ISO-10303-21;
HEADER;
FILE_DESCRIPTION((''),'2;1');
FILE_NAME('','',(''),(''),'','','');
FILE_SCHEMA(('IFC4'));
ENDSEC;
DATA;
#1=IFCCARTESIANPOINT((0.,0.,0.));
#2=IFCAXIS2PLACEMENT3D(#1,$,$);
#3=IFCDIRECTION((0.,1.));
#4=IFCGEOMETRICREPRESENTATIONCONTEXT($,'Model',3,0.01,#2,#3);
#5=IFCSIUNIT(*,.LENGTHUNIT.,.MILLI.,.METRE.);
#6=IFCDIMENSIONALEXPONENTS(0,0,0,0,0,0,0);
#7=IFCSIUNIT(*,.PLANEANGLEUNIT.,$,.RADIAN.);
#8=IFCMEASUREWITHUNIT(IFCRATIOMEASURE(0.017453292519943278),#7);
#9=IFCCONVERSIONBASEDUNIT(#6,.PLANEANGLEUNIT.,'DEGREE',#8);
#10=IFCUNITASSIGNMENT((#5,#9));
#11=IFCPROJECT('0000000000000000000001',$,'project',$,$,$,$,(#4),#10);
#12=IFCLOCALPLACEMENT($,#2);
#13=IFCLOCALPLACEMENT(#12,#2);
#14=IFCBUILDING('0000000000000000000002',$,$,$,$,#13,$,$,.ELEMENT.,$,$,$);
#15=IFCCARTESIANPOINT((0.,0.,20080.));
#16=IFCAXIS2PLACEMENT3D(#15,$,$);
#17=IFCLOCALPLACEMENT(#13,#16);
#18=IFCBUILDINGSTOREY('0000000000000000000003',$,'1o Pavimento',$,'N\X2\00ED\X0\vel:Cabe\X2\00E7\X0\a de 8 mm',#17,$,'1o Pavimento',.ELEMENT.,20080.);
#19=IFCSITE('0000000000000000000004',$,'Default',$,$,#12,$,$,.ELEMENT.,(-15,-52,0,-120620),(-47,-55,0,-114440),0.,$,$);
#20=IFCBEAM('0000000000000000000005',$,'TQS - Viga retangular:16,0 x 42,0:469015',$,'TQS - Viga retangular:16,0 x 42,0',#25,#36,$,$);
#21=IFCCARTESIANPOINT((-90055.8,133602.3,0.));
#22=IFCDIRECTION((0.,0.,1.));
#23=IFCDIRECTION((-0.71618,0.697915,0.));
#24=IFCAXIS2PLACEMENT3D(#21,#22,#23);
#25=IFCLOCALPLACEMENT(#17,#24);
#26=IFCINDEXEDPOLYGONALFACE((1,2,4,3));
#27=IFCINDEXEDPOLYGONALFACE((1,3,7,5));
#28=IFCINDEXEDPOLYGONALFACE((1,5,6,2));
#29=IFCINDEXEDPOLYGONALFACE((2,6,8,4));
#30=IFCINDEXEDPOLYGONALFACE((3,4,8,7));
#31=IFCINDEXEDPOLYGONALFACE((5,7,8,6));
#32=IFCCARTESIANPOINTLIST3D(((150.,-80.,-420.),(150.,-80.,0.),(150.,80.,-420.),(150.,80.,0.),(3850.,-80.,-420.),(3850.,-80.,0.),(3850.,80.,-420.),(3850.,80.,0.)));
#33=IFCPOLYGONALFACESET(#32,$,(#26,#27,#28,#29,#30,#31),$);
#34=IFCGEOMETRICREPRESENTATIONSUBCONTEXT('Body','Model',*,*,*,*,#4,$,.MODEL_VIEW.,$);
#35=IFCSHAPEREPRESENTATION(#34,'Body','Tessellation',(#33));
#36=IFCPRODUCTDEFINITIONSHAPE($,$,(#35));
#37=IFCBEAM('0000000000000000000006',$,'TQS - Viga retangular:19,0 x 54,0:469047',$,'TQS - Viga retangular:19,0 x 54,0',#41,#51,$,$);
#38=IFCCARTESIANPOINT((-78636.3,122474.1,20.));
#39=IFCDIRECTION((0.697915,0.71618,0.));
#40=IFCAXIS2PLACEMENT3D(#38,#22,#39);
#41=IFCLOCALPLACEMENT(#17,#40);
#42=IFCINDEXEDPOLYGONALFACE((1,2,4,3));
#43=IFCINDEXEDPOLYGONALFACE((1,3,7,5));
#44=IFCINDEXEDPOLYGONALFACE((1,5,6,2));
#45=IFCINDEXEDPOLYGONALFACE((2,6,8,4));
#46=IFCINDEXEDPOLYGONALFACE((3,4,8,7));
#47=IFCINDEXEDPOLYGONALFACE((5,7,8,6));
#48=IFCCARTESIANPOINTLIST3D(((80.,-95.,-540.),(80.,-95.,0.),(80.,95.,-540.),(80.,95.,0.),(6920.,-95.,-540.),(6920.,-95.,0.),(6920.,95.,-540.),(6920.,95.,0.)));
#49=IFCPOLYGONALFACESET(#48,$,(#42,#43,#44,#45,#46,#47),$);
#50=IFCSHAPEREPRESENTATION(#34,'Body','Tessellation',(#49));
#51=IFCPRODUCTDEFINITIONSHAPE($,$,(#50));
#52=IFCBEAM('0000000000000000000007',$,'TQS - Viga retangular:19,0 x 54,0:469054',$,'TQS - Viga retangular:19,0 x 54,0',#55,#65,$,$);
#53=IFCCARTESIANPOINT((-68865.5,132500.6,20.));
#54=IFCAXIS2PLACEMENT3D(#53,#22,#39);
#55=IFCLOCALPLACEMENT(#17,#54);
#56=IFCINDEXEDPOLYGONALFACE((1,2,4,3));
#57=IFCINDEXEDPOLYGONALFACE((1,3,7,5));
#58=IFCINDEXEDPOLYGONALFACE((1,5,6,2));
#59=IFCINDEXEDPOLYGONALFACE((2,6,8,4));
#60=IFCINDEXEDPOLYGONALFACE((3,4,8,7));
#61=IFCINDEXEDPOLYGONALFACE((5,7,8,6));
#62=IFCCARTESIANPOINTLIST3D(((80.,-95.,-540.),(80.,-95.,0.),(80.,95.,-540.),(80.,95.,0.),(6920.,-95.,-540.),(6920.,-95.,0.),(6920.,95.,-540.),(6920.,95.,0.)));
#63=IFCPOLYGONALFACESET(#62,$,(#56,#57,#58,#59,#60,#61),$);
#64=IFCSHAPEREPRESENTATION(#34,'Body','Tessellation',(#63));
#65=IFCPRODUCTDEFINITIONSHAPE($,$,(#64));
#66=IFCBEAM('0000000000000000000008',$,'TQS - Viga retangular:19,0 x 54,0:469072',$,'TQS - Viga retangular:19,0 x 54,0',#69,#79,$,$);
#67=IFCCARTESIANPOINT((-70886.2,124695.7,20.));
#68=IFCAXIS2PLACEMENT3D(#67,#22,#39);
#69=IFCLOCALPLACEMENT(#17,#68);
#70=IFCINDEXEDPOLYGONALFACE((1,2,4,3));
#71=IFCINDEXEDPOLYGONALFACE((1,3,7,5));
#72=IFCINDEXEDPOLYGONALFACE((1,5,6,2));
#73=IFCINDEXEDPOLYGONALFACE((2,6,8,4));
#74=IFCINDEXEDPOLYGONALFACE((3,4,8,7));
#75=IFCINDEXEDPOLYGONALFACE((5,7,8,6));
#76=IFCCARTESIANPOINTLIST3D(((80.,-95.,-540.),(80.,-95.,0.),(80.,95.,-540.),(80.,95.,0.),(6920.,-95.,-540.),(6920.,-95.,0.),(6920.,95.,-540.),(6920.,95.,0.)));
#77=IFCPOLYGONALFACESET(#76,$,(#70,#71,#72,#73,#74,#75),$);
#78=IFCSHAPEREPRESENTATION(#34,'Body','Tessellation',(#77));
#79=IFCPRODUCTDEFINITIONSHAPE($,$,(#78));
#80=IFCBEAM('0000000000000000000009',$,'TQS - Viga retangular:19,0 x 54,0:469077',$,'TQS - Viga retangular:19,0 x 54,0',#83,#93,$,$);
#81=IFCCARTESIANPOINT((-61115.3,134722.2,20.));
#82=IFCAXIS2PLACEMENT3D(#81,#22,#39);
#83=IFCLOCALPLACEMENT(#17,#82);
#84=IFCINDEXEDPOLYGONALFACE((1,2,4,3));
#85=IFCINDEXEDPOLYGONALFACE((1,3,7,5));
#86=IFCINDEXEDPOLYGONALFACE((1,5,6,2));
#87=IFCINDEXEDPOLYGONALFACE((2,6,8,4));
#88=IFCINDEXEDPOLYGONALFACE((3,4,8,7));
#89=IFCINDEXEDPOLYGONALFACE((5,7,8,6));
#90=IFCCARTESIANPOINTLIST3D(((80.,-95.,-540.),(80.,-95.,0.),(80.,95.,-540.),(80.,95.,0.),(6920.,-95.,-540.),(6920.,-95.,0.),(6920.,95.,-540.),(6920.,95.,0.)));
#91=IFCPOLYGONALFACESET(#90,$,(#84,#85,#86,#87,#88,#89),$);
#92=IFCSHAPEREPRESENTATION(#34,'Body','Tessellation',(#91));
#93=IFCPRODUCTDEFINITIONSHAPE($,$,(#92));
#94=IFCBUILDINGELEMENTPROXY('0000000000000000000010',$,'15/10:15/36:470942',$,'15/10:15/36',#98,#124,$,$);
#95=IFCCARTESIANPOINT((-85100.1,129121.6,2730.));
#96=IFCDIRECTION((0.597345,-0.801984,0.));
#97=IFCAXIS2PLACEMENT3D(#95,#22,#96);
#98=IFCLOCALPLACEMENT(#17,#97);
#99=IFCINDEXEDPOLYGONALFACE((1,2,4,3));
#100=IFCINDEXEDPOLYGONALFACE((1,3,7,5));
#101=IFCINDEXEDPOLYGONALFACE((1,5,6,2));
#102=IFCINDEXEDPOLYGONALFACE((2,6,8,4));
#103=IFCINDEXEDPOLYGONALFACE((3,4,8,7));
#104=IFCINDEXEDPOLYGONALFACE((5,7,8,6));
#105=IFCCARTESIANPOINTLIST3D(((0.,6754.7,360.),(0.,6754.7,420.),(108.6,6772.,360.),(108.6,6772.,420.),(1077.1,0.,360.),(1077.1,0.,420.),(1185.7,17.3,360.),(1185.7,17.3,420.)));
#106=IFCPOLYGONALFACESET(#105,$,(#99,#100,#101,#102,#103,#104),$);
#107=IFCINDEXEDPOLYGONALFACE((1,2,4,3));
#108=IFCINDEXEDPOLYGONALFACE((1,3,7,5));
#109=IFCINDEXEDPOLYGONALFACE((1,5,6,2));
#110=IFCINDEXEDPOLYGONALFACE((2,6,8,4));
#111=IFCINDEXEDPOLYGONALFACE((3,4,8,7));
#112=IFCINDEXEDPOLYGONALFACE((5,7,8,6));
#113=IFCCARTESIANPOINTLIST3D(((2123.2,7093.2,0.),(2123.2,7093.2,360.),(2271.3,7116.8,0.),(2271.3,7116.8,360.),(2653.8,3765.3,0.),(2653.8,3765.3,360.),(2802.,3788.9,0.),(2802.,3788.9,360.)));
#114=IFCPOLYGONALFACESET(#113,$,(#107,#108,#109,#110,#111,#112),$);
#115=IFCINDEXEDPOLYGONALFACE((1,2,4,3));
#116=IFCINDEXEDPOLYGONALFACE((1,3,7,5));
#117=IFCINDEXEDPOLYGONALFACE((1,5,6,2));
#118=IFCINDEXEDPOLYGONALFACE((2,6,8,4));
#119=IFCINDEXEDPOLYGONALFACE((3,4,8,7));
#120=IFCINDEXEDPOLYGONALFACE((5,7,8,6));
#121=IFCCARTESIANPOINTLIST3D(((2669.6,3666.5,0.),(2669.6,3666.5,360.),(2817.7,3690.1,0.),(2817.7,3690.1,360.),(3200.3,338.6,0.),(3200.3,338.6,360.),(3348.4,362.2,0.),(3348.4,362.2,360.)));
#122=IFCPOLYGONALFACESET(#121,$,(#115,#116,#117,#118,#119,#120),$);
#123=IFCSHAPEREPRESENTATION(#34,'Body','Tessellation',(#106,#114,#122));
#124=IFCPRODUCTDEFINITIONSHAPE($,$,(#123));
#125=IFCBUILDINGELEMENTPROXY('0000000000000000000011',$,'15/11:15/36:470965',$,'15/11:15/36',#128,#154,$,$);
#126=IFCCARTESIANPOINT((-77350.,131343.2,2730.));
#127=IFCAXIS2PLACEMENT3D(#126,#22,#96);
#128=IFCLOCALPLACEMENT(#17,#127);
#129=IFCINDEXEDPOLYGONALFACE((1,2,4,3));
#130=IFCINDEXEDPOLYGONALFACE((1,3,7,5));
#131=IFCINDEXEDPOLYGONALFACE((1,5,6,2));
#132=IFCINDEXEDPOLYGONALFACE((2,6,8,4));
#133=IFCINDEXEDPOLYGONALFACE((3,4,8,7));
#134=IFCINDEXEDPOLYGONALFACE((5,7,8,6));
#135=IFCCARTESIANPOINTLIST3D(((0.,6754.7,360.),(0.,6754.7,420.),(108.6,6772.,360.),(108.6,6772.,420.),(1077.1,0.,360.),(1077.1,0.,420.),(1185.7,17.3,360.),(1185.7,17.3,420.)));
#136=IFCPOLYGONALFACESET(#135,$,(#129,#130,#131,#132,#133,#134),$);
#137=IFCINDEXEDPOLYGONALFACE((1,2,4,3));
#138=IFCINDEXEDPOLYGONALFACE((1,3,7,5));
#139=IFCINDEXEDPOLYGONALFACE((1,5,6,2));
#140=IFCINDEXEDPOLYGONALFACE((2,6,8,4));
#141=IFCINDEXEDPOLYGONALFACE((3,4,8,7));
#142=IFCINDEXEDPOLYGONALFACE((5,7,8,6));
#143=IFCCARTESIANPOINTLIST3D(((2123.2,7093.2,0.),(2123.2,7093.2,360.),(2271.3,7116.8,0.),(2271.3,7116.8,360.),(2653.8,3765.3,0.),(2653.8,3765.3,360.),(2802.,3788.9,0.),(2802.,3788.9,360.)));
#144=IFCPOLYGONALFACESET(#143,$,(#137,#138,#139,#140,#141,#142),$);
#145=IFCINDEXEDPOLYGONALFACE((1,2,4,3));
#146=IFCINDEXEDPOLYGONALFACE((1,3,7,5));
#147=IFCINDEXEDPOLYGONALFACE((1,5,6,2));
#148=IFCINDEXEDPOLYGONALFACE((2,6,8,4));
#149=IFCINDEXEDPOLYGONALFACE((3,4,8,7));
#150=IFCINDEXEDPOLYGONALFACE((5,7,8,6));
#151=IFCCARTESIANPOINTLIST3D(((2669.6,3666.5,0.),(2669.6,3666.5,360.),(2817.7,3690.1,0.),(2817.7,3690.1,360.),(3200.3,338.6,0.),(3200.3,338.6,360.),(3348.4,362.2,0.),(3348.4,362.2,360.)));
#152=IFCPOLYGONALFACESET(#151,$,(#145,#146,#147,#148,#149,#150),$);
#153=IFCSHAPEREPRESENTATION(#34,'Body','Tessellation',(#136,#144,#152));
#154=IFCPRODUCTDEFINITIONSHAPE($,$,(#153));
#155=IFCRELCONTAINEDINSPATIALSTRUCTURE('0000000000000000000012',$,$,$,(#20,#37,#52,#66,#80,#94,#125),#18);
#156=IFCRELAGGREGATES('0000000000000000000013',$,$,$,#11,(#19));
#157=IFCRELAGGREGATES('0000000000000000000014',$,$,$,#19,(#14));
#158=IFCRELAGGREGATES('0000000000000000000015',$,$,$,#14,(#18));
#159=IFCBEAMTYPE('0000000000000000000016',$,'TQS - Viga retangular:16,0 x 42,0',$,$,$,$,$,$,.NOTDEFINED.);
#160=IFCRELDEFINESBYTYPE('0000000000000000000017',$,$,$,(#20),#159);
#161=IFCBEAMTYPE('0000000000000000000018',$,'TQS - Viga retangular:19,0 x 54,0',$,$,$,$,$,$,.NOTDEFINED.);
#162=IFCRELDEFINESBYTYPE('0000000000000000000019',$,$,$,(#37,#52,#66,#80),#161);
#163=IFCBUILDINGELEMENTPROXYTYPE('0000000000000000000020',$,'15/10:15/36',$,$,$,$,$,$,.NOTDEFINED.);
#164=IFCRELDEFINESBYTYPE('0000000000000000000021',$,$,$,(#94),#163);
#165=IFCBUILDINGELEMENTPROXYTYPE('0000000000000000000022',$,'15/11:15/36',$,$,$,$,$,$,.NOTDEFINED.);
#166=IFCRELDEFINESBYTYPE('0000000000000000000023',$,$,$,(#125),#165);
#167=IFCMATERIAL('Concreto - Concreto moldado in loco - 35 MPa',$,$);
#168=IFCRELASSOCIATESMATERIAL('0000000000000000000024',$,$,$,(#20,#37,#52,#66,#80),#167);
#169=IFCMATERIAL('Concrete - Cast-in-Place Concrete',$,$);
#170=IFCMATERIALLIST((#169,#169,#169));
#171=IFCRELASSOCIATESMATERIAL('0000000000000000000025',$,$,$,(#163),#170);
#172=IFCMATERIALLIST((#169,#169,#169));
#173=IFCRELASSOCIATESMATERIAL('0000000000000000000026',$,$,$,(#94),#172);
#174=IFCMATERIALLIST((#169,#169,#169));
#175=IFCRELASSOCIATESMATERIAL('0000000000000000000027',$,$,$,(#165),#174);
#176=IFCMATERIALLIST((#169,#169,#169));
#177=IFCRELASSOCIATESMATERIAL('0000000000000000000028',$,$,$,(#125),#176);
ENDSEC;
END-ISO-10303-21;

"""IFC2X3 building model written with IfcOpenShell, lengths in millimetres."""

from ifc_helpers import new_model, entity, si_unit, converted_unit, direction, frame, frame_2d, origin, origin_2d_with_axis, place, context, subcontext, project, spatial, rectangle, extrude, source, transform, mapped, material, material_list, type_object, type_shapes, element, save


model = new_model("IFC2X3")

# Units and contexts
model_context = context("Model", 3, precision=0.01, world=origin(), true_north=direction((0.0, 1.0)))
body_context = subcontext(model_context, "Body", "Model", "MODEL_VIEW")
ifc_project = project(units=[si_unit("LENGTHUNIT", "METRE", prefix="MILLI"), converted_unit("PLANEANGLEUNIT", "DEGREE", entity("IfcRatioMeasure", 0.017453292519943278), si_unit("PLANEANGLEUNIT", "RADIAN"), dimensions=[0, 0, 0, 0, 0, 0, 0])], contexts=[model_context])

# Site, building, storey
site_placement = place(None, origin())
site = spatial("IfcSite", under=ifc_project, at=site_placement, Name="Default", CompositionType="ELEMENT", RefLatitude=(-15, -52, 0, -120620), RefLongitude=(-47, -55, 0, -114440), RefElevation=0.0)
building_placement = place(site_placement, origin())
building = spatial("IfcBuilding", under=site, at=building_placement, CompositionType="ELEMENT")
storey_placement = place(building_placement, frame((0.0, 0.0, 20080.0)))
storey = spatial("IfcBuildingStorey", under=building, at=storey_placement, Name="1o Pavimento", ObjectType="Nível:Cabeça de 8 mm", LongName="1o Pavimento", CompositionType="ELEMENT", Elevation=20080.0)

# Beams
ifc_material_1 = material(Name="Concreto - Concreto moldado in loco - 35 MPa")
beam_type_1 = type_object("IfcBeamType", Name="TQS - Viga retangular:16,0 x 42,0", PredefinedType="NOTDEFINED")
beam_1_placement = place(storey_placement, frame((-90055.8, 133602.3, 0.0), z_axis=(0.0, 0.0, 1.0), x_axis=(-0.71618, 0.697915, 0.0)))
element("IfcBeam", 1, at=beam_1_placement, inside=storey, type_object=beam_type_1, material=ifc_material_1, Name="TQS - Viga retangular:16,0 x 42,0:469015", ObjectType="TQS - Viga retangular:16,0 x 42,0", context=body_context, shape_type="SweptSolid", body=[
    extrude(rectangle(XDim=420.0, YDim=160.0, at=frame_2d((0.0, 0.0), x_axis=(1.0, 0.0))), frame((150.0, 0.0, -210.0), z_axis=(1.0, 0.0, 0.0), x_axis=(0.0, 0.0, -1.0)), (0.0, 0.0, 1.0), 3700.0),
])
beam_type_2 = type_object("IfcBeamType", Name="TQS - Viga retangular:19,0 x 54,0", PredefinedType="NOTDEFINED")
beam_2_placement = place(storey_placement, frame((-78636.3, 122474.1, 20.0), z_axis=(0.0, 0.0, 1.0), x_axis=(0.697915, 0.71618, 0.0)))
element("IfcBeam", 2, at=beam_2_placement, inside=storey, type_object=beam_type_2, material=ifc_material_1, Name="TQS - Viga retangular:19,0 x 54,0:469047", ObjectType="TQS - Viga retangular:19,0 x 54,0", context=body_context, shape_type="SweptSolid", body=[
    extrude(rectangle(XDim=540.0, YDim=190.0, at=origin_2d_with_axis()), frame((80.0, 0.0, -270.0), z_axis=(1.0, 0.0, 0.0), x_axis=(0.0, 0.0, -1.0)), (0.0, 0.0, 1.0), 6840.0),
])
beam_3_placement = place(storey_placement, frame((-68865.5, 132500.6, 20.0), z_axis=(0.0, 0.0, 1.0), x_axis=(0.697915, 0.71618, 0.0)))
element("IfcBeam", 3, at=beam_3_placement, inside=storey, type_object=beam_type_2, material=ifc_material_1, Name="TQS - Viga retangular:19,0 x 54,0:469054", ObjectType="TQS - Viga retangular:19,0 x 54,0", context=body_context, shape_type="SweptSolid", body=[
    extrude(rectangle(XDim=540.0, YDim=190.0, at=frame_2d((0.0, 0.0), x_axis=(1.0, 0.0))), frame((80.0, 0.0, -270.0), z_axis=(1.0, 0.0, 0.0), x_axis=(0.0, 0.0, -1.0)), (0.0, 0.0, 1.0), 6840.0),
])
beam_4_placement = place(storey_placement, frame((-70886.2, 124695.7, 20.0), z_axis=(0.0, 0.0, 1.0), x_axis=(0.697915, 0.71618, 0.0)))
element("IfcBeam", 4, at=beam_4_placement, inside=storey, type_object=beam_type_2, material=ifc_material_1, Name="TQS - Viga retangular:19,0 x 54,0:469072", ObjectType="TQS - Viga retangular:19,0 x 54,0", context=body_context, shape_type="SweptSolid", body=[
    extrude(rectangle(XDim=540.0, YDim=190.0, at=frame_2d((0.0, 0.0), x_axis=(1.0, 0.0))), frame((80.0, 0.0, -270.0), z_axis=(1.0, 0.0, 0.0), x_axis=(0.0, 0.0, -1.0)), (0.0, 0.0, 1.0), 6840.0),
])
beam_5_placement = place(storey_placement, frame((-61115.3, 134722.2, 20.0), z_axis=(0.0, 0.0, 1.0), x_axis=(0.697915, 0.71618, 0.0)))
element("IfcBeam", 5, at=beam_5_placement, inside=storey, type_object=beam_type_2, material=ifc_material_1, Name="TQS - Viga retangular:19,0 x 54,0:469077", ObjectType="TQS - Viga retangular:19,0 x 54,0", context=body_context, shape_type="SweptSolid", body=[
    extrude(rectangle(XDim=540.0, YDim=190.0, at=frame_2d((0.0, 0.0), x_axis=(1.0, 0.0))), frame((80.0, 0.0, -270.0), z_axis=(1.0, 0.0, 0.0), x_axis=(0.0, 0.0, -1.0)), (0.0, 0.0, 1.0), 6840.0),
])

# Building element proxies
ifc_material_2 = material(Name="Concrete - Cast-in-Place Concrete")
ifc_material_list_1 = material_list([ifc_material_2, ifc_material_2, ifc_material_2])
ifc_material_list_2 = material_list([ifc_material_2, ifc_material_2, ifc_material_2])
building_element_proxy_type_1 = type_object("IfcBuildingElementProxyType", Name="15/10:15/36", PredefinedType="NOTDEFINED", material=ifc_material_list_2)
shared_shape_1 = source(origin(), body_context, "Body", "SweptSolid", [
    extrude(rectangle(XDim=110.0, YDim=6840.0, at=frame_2d((0.0, 0.0), x_axis=(1.0, 0.0))), frame((592.9, 3386.0, 360.0), z_axis=(0.0, 0.0, 1.0), x_axis=(-0.987524, -0.157469, 0.0)), (0.0, 0.0, 1.0), 60.0),
    extrude(rectangle(XDim=3370.0, YDim=150.0, at=frame_2d((0.0, 0.0), x_axis=(1.0, 0.0))), frame((2462.6, 5441.1, 0.0), z_axis=(0.0, 0.0, 1.0), x_axis=(0.157469, -0.987524, 0.0)), (0.0, 0.0, 1.0), 360.0),
    extrude(rectangle(XDim=3370.0, YDim=150.0, at=frame_2d((0.0, 0.0), x_axis=(1.0, 0.0))), frame((3009.0, 2014.3, 0.0), z_axis=(0.0, 0.0, 1.0), x_axis=(0.157469, -0.987524, 0.0)), (0.0, 0.0, 1.0), 360.0),
])
type_shapes(building_element_proxy_type_1, [shared_shape_1])
proxy_1_placement = place(storey_placement, frame((-85100.1, 129121.6, 2730.0), z_axis=(0.0, 0.0, 1.0), x_axis=(0.597345, -0.801984, 0.0)))
element("IfcBuildingElementProxy", 6, at=proxy_1_placement, inside=storey, type_object=building_element_proxy_type_1, material=ifc_material_list_1, Name="15/10:15/36:470942", ObjectType="15/10:15/36", context=body_context, shape_type="MappedRepresentation", body=[
    mapped(shared_shape_1, transform((0.0, 0.0, 0.0), scale=1.0)),
])
ifc_material_list_3 = material_list([ifc_material_2, ifc_material_2, ifc_material_2])
ifc_material_list_4 = material_list([ifc_material_2, ifc_material_2, ifc_material_2])
building_element_proxy_type_2 = type_object("IfcBuildingElementProxyType", Name="15/11:15/36", PredefinedType="NOTDEFINED", material=ifc_material_list_4)
shared_shape_2 = source(origin(), body_context, "Body", "SweptSolid", [
    extrude(rectangle(XDim=110.0, YDim=6840.0, at=frame_2d((0.0, 0.0), x_axis=(1.0, 0.0))), frame((592.9, 3386.0, 360.0), z_axis=(0.0, 0.0, 1.0), x_axis=(-0.987524, -0.157469, 0.0)), (0.0, 0.0, 1.0), 60.0),
    extrude(rectangle(XDim=3370.0, YDim=150.0, at=frame_2d((0.0, 0.0), x_axis=(1.0, 0.0))), frame((2462.6, 5441.1, 0.0), z_axis=(0.0, 0.0, 1.0), x_axis=(0.157469, -0.987524, 0.0)), (0.0, 0.0, 1.0), 360.0),
    extrude(rectangle(XDim=3370.0, YDim=150.0, at=frame_2d((0.0, 0.0), x_axis=(1.0, 0.0))), frame((3009.0, 2014.3, 0.0), z_axis=(0.0, 0.0, 1.0), x_axis=(0.157469, -0.987524, 0.0)), (0.0, 0.0, 1.0), 360.0),
])
type_shapes(building_element_proxy_type_2, [shared_shape_2])
proxy_2_placement = place(storey_placement, frame((-77350.0, 131343.2, 2730.0), z_axis=(0.0, 0.0, 1.0), x_axis=(0.597345, -0.801984, 0.0)))
element("IfcBuildingElementProxy", 7, at=proxy_2_placement, inside=storey, type_object=building_element_proxy_type_2, material=ifc_material_list_3, Name="15/11:15/36:470965", ObjectType="15/11:15/36", context=body_context, shape_type="MappedRepresentation", body=[
    mapped(shared_shape_2, transform((0.0, 0.0, 0.0), scale=1.0)),
])

save(model, "model.ifc")
